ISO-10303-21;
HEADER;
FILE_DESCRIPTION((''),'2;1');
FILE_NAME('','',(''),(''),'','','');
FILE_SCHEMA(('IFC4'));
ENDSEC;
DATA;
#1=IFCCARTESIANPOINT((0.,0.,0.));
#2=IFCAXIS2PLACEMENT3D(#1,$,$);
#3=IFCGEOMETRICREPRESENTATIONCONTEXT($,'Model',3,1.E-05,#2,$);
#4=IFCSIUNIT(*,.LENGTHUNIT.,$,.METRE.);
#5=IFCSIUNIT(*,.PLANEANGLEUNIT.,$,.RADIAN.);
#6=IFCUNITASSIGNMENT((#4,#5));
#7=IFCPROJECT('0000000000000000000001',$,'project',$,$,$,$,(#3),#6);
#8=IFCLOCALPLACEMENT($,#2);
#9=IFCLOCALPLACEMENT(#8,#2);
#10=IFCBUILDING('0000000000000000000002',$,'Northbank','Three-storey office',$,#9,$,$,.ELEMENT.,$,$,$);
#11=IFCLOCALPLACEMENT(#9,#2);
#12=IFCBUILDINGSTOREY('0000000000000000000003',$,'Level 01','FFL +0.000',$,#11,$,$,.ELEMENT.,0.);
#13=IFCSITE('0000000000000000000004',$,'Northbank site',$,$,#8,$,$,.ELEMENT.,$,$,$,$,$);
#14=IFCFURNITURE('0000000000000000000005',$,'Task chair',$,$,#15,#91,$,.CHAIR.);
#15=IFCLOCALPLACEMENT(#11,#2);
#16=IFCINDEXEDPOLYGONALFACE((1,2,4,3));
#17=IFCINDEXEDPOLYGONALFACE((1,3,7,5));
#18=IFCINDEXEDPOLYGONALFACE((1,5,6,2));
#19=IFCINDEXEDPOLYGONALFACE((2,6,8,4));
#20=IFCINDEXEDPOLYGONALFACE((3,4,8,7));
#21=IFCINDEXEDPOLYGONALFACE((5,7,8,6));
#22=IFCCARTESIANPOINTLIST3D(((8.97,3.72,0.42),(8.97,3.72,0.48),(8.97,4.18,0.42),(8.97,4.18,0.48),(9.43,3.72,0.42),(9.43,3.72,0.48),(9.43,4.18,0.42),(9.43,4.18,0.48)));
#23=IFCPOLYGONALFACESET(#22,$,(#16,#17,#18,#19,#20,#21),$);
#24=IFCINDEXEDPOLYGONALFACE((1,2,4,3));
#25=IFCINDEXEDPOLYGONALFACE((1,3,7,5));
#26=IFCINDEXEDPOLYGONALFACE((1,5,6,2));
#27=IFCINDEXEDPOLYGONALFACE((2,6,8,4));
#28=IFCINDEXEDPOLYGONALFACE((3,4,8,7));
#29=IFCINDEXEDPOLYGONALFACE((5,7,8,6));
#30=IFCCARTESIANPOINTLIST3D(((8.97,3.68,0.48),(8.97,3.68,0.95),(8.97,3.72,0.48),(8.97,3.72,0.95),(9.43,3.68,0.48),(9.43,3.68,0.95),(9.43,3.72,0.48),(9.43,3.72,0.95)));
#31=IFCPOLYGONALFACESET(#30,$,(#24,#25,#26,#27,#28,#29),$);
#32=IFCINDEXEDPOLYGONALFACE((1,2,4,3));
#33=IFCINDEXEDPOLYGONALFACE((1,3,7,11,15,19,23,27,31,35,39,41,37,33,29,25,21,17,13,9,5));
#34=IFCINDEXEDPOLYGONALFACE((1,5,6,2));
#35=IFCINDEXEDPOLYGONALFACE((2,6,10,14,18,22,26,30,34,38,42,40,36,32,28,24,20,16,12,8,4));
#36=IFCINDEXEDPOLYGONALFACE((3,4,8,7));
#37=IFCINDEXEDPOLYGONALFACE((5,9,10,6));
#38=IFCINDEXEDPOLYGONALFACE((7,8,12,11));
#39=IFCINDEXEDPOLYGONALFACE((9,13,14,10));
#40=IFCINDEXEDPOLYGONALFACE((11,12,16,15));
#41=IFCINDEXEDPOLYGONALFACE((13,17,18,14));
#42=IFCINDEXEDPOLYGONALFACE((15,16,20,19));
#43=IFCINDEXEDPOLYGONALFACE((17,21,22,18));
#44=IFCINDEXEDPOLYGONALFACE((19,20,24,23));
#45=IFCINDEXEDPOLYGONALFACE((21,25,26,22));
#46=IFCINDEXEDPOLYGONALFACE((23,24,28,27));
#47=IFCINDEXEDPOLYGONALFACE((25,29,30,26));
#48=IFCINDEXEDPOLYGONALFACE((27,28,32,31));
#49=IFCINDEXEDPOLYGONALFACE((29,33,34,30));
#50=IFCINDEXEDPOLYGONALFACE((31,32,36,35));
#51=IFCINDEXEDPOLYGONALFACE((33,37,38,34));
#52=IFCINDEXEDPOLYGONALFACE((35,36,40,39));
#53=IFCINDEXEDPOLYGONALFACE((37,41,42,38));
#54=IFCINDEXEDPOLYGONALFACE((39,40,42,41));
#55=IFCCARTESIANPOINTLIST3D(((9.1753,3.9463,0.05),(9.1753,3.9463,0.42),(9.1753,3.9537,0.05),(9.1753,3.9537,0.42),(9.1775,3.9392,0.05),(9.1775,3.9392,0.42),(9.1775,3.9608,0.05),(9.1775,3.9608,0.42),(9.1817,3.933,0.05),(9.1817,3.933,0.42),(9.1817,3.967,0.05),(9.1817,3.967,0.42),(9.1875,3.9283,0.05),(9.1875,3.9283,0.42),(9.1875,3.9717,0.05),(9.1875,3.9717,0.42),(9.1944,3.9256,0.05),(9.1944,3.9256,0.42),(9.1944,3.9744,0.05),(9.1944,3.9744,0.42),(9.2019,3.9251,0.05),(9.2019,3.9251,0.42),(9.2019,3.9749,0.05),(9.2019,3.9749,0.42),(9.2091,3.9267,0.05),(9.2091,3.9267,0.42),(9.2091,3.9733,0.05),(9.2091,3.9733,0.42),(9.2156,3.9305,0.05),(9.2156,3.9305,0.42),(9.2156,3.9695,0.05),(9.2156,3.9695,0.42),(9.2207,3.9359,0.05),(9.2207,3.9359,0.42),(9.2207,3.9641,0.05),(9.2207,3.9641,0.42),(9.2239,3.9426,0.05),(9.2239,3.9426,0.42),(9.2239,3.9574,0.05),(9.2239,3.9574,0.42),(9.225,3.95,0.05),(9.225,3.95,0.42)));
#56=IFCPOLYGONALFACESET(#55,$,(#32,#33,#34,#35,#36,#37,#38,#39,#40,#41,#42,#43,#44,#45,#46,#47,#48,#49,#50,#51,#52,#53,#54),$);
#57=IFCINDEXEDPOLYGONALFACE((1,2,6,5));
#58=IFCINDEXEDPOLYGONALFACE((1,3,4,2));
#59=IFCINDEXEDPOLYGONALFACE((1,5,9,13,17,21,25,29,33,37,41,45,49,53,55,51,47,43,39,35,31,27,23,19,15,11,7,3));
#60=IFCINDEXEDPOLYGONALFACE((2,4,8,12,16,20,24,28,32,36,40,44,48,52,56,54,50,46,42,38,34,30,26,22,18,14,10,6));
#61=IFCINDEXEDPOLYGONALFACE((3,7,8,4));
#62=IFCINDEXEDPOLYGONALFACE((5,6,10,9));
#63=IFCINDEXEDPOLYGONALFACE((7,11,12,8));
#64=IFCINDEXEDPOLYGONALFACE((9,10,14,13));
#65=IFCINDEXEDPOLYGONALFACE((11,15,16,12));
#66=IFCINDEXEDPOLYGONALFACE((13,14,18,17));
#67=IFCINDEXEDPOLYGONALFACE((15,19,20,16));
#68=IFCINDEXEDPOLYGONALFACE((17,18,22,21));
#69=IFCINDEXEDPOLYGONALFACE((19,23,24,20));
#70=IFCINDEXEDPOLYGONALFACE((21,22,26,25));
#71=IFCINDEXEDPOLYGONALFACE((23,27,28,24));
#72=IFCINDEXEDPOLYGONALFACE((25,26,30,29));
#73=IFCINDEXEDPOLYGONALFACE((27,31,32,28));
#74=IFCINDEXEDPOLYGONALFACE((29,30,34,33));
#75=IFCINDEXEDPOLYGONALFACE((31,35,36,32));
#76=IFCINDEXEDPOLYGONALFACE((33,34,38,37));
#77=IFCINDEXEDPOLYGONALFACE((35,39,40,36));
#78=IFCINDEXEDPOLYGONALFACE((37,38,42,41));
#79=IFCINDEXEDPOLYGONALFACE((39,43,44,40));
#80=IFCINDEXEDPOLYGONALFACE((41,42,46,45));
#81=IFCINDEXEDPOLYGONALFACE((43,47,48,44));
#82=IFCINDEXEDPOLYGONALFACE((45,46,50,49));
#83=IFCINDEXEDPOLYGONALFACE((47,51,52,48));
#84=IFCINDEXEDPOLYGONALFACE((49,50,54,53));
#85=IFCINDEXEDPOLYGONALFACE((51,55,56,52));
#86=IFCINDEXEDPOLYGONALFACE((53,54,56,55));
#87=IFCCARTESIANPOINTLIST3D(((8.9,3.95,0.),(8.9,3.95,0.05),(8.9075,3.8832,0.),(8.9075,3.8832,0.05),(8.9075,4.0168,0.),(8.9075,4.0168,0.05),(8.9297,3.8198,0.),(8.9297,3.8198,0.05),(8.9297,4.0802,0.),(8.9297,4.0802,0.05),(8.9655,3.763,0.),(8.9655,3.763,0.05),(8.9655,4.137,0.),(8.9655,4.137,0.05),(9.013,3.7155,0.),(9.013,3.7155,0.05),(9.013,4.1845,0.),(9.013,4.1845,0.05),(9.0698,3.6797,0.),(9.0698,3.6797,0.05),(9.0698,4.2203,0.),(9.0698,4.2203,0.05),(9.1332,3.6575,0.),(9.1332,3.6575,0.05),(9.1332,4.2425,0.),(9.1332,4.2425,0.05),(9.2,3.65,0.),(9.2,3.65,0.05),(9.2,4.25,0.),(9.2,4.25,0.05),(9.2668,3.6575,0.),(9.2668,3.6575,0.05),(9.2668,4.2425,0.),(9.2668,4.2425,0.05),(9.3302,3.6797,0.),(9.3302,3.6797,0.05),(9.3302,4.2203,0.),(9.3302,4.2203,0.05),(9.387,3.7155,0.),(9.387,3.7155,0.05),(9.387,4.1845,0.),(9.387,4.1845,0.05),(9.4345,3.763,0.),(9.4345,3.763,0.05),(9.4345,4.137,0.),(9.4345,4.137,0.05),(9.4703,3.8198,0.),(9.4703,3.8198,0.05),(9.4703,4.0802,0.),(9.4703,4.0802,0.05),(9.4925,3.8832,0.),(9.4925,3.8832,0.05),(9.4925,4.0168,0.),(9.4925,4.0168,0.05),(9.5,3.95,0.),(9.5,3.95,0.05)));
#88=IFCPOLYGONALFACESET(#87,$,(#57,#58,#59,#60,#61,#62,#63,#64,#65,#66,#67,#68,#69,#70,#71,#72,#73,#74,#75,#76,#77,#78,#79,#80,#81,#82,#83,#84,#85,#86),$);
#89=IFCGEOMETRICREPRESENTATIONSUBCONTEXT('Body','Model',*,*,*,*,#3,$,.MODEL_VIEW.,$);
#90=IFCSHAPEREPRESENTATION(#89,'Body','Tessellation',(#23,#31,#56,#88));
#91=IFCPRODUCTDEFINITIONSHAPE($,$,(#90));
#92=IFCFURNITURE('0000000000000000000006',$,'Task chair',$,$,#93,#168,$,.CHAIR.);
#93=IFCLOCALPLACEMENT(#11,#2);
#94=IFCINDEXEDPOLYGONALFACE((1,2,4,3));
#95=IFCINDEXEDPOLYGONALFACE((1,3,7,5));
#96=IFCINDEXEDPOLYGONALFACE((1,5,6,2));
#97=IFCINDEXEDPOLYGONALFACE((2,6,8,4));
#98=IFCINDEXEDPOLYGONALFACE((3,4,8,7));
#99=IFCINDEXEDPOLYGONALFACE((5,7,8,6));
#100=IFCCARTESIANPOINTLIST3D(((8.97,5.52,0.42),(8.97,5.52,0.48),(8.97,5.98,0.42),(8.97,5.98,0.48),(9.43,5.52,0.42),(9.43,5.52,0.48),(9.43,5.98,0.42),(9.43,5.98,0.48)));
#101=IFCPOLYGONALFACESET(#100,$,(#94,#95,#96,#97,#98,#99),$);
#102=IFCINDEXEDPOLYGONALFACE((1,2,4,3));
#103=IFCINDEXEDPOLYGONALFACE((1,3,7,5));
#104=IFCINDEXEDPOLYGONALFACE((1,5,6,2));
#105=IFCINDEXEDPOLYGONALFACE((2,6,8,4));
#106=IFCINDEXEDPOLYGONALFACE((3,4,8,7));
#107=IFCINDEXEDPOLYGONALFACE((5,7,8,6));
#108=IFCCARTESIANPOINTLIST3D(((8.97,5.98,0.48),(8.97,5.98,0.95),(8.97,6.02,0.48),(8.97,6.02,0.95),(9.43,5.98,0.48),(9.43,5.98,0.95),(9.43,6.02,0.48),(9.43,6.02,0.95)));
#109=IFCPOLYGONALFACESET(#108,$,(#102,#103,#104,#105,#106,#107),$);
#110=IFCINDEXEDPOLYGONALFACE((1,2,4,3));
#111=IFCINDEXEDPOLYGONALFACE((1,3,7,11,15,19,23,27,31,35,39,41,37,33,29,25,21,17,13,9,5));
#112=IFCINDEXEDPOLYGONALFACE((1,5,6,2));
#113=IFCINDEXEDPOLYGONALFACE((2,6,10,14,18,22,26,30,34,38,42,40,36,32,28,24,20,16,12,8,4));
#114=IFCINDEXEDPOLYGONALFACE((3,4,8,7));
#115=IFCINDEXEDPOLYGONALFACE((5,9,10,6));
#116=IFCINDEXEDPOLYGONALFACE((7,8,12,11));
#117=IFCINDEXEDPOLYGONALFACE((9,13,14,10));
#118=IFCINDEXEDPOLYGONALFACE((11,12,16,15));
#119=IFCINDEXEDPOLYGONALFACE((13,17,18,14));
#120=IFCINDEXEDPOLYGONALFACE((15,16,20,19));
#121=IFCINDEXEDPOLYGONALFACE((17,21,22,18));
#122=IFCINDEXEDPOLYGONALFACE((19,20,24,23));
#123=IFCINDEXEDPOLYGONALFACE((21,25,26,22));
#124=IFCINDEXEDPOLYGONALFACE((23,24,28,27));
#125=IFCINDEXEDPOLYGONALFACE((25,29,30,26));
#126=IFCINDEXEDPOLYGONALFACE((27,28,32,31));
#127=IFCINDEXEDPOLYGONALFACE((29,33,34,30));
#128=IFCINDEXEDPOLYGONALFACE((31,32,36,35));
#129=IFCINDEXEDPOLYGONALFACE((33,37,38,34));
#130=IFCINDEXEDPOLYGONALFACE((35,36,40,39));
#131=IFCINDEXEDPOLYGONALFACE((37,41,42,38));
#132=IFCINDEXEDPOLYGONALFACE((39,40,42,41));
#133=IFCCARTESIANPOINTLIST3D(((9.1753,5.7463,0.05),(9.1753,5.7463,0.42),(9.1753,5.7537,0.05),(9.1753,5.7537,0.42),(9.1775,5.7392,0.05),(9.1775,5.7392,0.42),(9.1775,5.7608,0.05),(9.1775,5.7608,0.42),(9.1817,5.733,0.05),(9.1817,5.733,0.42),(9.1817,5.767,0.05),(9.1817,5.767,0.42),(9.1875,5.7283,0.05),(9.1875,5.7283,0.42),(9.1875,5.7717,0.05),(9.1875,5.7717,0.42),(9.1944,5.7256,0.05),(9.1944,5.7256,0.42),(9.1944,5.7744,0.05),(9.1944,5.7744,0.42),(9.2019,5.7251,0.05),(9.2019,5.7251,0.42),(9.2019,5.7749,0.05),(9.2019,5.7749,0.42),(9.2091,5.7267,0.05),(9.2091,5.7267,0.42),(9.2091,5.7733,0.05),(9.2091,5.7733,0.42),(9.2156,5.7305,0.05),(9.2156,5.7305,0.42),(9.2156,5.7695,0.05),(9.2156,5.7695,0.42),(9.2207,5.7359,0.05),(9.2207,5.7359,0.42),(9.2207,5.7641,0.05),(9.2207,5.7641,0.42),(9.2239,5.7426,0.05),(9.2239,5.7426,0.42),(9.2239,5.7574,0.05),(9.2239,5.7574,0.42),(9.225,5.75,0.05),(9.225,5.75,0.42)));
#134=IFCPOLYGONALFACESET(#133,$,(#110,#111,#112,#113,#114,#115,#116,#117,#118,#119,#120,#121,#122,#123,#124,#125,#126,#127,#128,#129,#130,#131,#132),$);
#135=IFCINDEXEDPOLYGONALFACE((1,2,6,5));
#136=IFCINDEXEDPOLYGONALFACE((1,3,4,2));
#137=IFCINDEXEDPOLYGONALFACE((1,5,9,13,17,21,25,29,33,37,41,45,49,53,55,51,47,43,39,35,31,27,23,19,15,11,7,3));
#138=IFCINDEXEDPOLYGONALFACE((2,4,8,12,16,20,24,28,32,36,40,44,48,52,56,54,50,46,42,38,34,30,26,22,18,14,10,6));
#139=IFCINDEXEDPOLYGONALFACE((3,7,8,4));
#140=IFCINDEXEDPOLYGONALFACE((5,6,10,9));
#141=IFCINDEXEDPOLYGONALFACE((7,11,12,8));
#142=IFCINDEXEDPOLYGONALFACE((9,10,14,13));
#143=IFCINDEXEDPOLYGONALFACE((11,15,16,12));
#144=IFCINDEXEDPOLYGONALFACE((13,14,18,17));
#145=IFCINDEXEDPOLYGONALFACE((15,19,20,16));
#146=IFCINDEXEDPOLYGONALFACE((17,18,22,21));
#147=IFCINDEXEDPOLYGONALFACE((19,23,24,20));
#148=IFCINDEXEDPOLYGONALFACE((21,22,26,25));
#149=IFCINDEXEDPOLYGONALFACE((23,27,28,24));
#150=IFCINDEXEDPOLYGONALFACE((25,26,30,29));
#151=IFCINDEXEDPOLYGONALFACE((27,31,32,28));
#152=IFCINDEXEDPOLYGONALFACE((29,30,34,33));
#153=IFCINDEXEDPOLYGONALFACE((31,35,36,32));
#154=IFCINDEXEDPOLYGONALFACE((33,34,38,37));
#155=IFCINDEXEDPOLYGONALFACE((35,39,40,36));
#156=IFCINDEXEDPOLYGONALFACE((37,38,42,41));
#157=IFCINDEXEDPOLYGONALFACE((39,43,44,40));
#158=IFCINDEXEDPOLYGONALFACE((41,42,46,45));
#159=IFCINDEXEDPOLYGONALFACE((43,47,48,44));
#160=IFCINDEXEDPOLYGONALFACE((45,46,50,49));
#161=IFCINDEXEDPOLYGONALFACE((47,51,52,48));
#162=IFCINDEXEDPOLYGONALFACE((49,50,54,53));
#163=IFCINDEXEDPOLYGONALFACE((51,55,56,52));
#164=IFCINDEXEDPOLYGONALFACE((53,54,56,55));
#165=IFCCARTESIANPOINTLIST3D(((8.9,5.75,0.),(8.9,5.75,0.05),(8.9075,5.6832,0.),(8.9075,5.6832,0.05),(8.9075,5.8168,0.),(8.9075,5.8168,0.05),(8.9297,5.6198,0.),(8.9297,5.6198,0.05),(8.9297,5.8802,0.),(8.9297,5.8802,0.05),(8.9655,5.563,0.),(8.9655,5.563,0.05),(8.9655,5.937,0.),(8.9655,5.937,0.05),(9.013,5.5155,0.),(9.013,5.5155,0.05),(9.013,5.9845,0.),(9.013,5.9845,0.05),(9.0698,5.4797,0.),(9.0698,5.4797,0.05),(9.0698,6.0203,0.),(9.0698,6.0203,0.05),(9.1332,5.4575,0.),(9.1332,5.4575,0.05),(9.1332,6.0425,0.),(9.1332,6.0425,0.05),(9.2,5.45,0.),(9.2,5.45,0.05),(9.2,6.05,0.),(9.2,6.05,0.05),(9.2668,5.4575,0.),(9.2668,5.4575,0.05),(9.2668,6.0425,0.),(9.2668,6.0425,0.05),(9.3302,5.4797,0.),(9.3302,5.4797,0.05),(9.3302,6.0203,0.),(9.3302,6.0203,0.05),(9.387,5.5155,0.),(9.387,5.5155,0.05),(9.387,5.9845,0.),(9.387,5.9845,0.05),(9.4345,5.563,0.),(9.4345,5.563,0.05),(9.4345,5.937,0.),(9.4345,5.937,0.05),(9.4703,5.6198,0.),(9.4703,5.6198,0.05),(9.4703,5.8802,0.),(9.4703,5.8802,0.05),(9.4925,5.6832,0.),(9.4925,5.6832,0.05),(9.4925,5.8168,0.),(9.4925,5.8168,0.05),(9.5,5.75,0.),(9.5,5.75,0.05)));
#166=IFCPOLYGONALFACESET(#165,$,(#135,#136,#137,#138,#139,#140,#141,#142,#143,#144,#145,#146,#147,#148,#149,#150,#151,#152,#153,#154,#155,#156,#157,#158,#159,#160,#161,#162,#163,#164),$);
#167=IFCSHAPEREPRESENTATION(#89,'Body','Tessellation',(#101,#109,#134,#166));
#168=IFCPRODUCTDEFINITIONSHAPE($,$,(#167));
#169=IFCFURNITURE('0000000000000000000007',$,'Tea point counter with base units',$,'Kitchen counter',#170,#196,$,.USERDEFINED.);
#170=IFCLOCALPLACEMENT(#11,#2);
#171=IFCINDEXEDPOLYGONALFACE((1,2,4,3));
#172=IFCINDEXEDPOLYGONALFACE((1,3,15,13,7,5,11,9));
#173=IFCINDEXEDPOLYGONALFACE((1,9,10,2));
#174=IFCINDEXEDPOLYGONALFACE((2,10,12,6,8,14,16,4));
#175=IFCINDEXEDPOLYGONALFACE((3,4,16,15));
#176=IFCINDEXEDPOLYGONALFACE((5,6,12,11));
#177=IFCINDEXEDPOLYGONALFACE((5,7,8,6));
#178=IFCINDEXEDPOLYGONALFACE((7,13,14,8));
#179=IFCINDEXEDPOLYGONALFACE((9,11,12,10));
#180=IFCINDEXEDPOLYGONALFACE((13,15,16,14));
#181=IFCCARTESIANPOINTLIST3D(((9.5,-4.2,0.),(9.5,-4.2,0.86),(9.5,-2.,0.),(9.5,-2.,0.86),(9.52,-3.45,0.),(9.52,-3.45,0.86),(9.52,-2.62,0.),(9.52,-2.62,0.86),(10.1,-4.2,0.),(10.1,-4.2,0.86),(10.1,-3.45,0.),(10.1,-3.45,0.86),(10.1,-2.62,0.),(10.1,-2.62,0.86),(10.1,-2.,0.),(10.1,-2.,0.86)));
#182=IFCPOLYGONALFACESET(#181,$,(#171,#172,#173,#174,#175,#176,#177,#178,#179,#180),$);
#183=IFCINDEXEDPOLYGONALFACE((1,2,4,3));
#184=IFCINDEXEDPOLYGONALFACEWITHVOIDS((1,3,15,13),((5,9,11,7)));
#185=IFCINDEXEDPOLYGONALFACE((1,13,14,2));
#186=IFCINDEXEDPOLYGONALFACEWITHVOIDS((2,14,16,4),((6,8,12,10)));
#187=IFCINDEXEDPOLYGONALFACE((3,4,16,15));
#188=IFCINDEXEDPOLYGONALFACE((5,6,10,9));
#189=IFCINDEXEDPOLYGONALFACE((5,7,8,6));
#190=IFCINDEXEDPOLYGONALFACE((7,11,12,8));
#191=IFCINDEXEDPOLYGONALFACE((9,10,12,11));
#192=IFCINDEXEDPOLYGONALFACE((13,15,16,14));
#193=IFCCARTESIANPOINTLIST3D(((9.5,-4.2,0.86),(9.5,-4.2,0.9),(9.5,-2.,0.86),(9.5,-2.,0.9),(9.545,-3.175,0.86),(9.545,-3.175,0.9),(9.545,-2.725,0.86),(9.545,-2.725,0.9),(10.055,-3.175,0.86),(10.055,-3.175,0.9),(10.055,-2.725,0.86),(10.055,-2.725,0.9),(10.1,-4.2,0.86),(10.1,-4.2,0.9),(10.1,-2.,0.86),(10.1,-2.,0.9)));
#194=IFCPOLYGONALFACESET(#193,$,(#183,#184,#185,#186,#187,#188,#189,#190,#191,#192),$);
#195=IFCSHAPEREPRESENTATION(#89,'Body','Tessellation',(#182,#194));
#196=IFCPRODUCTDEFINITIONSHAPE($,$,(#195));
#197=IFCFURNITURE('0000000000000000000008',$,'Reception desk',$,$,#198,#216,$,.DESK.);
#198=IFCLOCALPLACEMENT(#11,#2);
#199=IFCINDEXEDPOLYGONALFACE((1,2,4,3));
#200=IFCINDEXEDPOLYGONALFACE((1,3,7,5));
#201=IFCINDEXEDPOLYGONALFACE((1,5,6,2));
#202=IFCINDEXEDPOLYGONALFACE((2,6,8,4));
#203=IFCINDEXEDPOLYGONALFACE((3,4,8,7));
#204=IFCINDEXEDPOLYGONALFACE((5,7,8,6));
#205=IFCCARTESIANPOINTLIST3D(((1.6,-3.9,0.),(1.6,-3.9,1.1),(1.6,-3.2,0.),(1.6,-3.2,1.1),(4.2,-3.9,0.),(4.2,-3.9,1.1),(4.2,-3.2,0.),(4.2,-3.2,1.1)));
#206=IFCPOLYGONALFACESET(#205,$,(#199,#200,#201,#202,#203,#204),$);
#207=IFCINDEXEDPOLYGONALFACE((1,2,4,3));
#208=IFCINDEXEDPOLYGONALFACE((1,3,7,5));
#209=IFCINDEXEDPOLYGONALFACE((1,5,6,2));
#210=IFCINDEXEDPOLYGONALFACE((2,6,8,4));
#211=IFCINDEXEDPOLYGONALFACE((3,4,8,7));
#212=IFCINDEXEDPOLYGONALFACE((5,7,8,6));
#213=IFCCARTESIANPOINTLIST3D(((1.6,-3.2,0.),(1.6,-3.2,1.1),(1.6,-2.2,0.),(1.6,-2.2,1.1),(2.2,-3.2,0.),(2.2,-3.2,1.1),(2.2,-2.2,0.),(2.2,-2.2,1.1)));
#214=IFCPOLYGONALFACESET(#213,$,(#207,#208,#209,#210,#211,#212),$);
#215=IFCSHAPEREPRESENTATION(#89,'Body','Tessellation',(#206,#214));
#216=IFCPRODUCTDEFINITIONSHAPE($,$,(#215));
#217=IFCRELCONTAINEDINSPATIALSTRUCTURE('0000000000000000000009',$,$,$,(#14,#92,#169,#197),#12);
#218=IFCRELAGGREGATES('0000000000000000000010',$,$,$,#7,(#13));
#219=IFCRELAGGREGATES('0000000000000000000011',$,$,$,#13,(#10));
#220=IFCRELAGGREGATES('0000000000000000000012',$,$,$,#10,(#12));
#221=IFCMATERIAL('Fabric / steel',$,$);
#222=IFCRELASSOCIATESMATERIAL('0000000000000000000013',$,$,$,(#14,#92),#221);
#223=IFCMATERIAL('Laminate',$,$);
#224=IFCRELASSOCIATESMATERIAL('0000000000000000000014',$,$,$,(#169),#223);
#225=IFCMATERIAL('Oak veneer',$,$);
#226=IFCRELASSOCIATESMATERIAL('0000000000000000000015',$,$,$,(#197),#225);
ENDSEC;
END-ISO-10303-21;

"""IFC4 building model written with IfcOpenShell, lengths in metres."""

from ifc_helpers import new_model, si_unit, frame, origin, place, context, subcontext, project, spatial, polyline, rectangle, circle, outline, extrude, material, element, save


model = new_model("IFC4")

# Units and contexts
model_context = context("Model", 3, precision=1e-05, world=origin())
body_context = subcontext(model_context, "Body", "Model", "MODEL_VIEW")
ifc_project = project(units=[si_unit("LENGTHUNIT", "METRE"), si_unit("PLANEANGLEUNIT", "RADIAN")], contexts=[model_context])

# Site, building, storey
site_placement = place(None, origin())
site = spatial("IfcSite", under=ifc_project, at=site_placement, Name="Northbank site", CompositionType="ELEMENT")
building_placement = place(site_placement, origin())
building = spatial("IfcBuilding", under=site, at=building_placement, Name="Northbank", Description="Three-storey office", CompositionType="ELEMENT")
storey_placement = place(building_placement, origin())
storey = spatial("IfcBuildingStorey", under=building, at=storey_placement, Name="Level 01", Description="FFL +0.000", CompositionType="ELEMENT", Elevation=0.0)

# Furniture
ifc_material_1 = material(Name="Fabric / steel")
ifc_material_2 = material(Name="Oak veneer")
furniture_1_placement = place(storey_placement, origin())
element("IfcFurniture", 1, at=furniture_1_placement, inside=storey, material=ifc_material_1, Name="Task chair", PredefinedType="CHAIR", context=body_context, shape_type="SweptSolid", body=[
    extrude(rectangle(XDim=0.46, YDim=0.46), frame((9.2, 3.95, 0.42)), (0.0, 0.0, 1.0), 0.06),
    extrude(rectangle(XDim=0.46, YDim=0.04), frame((9.2, 3.7, 0.48)), (0.0, 0.0, 1.0), 0.47),
    extrude(circle(Radius=0.025), frame((9.2, 3.95, 0.05), z_axis=(0.0, 0.0, 1.0), x_axis=(1.0, 0.0, 0.0)), (0.0, 0.0, 1.0), 0.37),
    extrude(circle(Radius=0.3), frame((9.2, 3.95, 0.0), z_axis=(0.0, 0.0, 1.0), x_axis=(1.0, 0.0, 0.0)), (0.0, 0.0, 1.0), 0.05),
])
furniture_2_placement = place(storey_placement, origin())
element("IfcFurniture", 2, at=furniture_2_placement, inside=storey, material=ifc_material_1, Name="Task chair", PredefinedType="CHAIR", context=body_context, shape_type="SweptSolid", body=[
    extrude(rectangle(XDim=0.46, YDim=0.46), frame((9.2, 5.75, 0.42)), (0.0, 0.0, 1.0), 0.06),
    extrude(rectangle(XDim=0.46, YDim=0.04), frame((9.2, 6.0, 0.48)), (0.0, 0.0, 1.0), 0.47),
    extrude(circle(Radius=0.025), frame((9.2, 5.75, 0.05), z_axis=(0.0, 0.0, 1.0), x_axis=(1.0, 0.0, 0.0)), (0.0, 0.0, 1.0), 0.37),
    extrude(circle(Radius=0.3), frame((9.2, 5.75, 0.0), z_axis=(0.0, 0.0, 1.0), x_axis=(1.0, 0.0, 0.0)), (0.0, 0.0, 1.0), 0.05),
])
ifc_material_3 = material(Name="Laminate")
furniture_3_placement = place(storey_placement, origin())
element("IfcFurniture", 3, at=furniture_3_placement, inside=storey, material=ifc_material_3, Name="Tea point counter with base units", ObjectType="Kitchen counter", PredefinedType="USERDEFINED", context=body_context, shape_type="SweptSolid", body=[
    extrude(outline(polyline([(9.5, -4.2), (10.1, -4.2), (10.1, -3.45), (9.52, -3.45), (9.52, -2.62), (10.1, -2.62), (10.1, -2.0), (9.5, -2.0), (9.5, -4.2)])), origin(), (0.0, 0.0, 1.0), 0.86),
    extrude(outline(polyline([(9.5, -4.2), (10.1, -4.2), (10.1, -2.0), (9.5, -2.0), (9.5, -4.2)]), holes=[polyline([(9.545, -3.175), (9.545, -2.725), (10.055, -2.725), (10.055, -3.175), (9.545, -3.175)])]), frame((0.0, 0.0, 0.86)), (0.0, 0.0, 1.0), 0.04),
])
furniture_4_placement = place(storey_placement, origin())
element("IfcFurniture", 4, at=furniture_4_placement, inside=storey, material=ifc_material_2, Name="Reception desk", PredefinedType="DESK", context=body_context, shape_type="SweptSolid", body=[
    extrude(rectangle(XDim=2.6, YDim=0.7), frame((2.9, -3.55, 0.0)), (0.0, 0.0, 1.0), 1.1),
    extrude(rectangle(XDim=0.6, YDim=1.0), frame((1.9, -2.7, 0.0)), (0.0, 0.0, 1.0), 1.1),
])

save(model, "model.ifc")
